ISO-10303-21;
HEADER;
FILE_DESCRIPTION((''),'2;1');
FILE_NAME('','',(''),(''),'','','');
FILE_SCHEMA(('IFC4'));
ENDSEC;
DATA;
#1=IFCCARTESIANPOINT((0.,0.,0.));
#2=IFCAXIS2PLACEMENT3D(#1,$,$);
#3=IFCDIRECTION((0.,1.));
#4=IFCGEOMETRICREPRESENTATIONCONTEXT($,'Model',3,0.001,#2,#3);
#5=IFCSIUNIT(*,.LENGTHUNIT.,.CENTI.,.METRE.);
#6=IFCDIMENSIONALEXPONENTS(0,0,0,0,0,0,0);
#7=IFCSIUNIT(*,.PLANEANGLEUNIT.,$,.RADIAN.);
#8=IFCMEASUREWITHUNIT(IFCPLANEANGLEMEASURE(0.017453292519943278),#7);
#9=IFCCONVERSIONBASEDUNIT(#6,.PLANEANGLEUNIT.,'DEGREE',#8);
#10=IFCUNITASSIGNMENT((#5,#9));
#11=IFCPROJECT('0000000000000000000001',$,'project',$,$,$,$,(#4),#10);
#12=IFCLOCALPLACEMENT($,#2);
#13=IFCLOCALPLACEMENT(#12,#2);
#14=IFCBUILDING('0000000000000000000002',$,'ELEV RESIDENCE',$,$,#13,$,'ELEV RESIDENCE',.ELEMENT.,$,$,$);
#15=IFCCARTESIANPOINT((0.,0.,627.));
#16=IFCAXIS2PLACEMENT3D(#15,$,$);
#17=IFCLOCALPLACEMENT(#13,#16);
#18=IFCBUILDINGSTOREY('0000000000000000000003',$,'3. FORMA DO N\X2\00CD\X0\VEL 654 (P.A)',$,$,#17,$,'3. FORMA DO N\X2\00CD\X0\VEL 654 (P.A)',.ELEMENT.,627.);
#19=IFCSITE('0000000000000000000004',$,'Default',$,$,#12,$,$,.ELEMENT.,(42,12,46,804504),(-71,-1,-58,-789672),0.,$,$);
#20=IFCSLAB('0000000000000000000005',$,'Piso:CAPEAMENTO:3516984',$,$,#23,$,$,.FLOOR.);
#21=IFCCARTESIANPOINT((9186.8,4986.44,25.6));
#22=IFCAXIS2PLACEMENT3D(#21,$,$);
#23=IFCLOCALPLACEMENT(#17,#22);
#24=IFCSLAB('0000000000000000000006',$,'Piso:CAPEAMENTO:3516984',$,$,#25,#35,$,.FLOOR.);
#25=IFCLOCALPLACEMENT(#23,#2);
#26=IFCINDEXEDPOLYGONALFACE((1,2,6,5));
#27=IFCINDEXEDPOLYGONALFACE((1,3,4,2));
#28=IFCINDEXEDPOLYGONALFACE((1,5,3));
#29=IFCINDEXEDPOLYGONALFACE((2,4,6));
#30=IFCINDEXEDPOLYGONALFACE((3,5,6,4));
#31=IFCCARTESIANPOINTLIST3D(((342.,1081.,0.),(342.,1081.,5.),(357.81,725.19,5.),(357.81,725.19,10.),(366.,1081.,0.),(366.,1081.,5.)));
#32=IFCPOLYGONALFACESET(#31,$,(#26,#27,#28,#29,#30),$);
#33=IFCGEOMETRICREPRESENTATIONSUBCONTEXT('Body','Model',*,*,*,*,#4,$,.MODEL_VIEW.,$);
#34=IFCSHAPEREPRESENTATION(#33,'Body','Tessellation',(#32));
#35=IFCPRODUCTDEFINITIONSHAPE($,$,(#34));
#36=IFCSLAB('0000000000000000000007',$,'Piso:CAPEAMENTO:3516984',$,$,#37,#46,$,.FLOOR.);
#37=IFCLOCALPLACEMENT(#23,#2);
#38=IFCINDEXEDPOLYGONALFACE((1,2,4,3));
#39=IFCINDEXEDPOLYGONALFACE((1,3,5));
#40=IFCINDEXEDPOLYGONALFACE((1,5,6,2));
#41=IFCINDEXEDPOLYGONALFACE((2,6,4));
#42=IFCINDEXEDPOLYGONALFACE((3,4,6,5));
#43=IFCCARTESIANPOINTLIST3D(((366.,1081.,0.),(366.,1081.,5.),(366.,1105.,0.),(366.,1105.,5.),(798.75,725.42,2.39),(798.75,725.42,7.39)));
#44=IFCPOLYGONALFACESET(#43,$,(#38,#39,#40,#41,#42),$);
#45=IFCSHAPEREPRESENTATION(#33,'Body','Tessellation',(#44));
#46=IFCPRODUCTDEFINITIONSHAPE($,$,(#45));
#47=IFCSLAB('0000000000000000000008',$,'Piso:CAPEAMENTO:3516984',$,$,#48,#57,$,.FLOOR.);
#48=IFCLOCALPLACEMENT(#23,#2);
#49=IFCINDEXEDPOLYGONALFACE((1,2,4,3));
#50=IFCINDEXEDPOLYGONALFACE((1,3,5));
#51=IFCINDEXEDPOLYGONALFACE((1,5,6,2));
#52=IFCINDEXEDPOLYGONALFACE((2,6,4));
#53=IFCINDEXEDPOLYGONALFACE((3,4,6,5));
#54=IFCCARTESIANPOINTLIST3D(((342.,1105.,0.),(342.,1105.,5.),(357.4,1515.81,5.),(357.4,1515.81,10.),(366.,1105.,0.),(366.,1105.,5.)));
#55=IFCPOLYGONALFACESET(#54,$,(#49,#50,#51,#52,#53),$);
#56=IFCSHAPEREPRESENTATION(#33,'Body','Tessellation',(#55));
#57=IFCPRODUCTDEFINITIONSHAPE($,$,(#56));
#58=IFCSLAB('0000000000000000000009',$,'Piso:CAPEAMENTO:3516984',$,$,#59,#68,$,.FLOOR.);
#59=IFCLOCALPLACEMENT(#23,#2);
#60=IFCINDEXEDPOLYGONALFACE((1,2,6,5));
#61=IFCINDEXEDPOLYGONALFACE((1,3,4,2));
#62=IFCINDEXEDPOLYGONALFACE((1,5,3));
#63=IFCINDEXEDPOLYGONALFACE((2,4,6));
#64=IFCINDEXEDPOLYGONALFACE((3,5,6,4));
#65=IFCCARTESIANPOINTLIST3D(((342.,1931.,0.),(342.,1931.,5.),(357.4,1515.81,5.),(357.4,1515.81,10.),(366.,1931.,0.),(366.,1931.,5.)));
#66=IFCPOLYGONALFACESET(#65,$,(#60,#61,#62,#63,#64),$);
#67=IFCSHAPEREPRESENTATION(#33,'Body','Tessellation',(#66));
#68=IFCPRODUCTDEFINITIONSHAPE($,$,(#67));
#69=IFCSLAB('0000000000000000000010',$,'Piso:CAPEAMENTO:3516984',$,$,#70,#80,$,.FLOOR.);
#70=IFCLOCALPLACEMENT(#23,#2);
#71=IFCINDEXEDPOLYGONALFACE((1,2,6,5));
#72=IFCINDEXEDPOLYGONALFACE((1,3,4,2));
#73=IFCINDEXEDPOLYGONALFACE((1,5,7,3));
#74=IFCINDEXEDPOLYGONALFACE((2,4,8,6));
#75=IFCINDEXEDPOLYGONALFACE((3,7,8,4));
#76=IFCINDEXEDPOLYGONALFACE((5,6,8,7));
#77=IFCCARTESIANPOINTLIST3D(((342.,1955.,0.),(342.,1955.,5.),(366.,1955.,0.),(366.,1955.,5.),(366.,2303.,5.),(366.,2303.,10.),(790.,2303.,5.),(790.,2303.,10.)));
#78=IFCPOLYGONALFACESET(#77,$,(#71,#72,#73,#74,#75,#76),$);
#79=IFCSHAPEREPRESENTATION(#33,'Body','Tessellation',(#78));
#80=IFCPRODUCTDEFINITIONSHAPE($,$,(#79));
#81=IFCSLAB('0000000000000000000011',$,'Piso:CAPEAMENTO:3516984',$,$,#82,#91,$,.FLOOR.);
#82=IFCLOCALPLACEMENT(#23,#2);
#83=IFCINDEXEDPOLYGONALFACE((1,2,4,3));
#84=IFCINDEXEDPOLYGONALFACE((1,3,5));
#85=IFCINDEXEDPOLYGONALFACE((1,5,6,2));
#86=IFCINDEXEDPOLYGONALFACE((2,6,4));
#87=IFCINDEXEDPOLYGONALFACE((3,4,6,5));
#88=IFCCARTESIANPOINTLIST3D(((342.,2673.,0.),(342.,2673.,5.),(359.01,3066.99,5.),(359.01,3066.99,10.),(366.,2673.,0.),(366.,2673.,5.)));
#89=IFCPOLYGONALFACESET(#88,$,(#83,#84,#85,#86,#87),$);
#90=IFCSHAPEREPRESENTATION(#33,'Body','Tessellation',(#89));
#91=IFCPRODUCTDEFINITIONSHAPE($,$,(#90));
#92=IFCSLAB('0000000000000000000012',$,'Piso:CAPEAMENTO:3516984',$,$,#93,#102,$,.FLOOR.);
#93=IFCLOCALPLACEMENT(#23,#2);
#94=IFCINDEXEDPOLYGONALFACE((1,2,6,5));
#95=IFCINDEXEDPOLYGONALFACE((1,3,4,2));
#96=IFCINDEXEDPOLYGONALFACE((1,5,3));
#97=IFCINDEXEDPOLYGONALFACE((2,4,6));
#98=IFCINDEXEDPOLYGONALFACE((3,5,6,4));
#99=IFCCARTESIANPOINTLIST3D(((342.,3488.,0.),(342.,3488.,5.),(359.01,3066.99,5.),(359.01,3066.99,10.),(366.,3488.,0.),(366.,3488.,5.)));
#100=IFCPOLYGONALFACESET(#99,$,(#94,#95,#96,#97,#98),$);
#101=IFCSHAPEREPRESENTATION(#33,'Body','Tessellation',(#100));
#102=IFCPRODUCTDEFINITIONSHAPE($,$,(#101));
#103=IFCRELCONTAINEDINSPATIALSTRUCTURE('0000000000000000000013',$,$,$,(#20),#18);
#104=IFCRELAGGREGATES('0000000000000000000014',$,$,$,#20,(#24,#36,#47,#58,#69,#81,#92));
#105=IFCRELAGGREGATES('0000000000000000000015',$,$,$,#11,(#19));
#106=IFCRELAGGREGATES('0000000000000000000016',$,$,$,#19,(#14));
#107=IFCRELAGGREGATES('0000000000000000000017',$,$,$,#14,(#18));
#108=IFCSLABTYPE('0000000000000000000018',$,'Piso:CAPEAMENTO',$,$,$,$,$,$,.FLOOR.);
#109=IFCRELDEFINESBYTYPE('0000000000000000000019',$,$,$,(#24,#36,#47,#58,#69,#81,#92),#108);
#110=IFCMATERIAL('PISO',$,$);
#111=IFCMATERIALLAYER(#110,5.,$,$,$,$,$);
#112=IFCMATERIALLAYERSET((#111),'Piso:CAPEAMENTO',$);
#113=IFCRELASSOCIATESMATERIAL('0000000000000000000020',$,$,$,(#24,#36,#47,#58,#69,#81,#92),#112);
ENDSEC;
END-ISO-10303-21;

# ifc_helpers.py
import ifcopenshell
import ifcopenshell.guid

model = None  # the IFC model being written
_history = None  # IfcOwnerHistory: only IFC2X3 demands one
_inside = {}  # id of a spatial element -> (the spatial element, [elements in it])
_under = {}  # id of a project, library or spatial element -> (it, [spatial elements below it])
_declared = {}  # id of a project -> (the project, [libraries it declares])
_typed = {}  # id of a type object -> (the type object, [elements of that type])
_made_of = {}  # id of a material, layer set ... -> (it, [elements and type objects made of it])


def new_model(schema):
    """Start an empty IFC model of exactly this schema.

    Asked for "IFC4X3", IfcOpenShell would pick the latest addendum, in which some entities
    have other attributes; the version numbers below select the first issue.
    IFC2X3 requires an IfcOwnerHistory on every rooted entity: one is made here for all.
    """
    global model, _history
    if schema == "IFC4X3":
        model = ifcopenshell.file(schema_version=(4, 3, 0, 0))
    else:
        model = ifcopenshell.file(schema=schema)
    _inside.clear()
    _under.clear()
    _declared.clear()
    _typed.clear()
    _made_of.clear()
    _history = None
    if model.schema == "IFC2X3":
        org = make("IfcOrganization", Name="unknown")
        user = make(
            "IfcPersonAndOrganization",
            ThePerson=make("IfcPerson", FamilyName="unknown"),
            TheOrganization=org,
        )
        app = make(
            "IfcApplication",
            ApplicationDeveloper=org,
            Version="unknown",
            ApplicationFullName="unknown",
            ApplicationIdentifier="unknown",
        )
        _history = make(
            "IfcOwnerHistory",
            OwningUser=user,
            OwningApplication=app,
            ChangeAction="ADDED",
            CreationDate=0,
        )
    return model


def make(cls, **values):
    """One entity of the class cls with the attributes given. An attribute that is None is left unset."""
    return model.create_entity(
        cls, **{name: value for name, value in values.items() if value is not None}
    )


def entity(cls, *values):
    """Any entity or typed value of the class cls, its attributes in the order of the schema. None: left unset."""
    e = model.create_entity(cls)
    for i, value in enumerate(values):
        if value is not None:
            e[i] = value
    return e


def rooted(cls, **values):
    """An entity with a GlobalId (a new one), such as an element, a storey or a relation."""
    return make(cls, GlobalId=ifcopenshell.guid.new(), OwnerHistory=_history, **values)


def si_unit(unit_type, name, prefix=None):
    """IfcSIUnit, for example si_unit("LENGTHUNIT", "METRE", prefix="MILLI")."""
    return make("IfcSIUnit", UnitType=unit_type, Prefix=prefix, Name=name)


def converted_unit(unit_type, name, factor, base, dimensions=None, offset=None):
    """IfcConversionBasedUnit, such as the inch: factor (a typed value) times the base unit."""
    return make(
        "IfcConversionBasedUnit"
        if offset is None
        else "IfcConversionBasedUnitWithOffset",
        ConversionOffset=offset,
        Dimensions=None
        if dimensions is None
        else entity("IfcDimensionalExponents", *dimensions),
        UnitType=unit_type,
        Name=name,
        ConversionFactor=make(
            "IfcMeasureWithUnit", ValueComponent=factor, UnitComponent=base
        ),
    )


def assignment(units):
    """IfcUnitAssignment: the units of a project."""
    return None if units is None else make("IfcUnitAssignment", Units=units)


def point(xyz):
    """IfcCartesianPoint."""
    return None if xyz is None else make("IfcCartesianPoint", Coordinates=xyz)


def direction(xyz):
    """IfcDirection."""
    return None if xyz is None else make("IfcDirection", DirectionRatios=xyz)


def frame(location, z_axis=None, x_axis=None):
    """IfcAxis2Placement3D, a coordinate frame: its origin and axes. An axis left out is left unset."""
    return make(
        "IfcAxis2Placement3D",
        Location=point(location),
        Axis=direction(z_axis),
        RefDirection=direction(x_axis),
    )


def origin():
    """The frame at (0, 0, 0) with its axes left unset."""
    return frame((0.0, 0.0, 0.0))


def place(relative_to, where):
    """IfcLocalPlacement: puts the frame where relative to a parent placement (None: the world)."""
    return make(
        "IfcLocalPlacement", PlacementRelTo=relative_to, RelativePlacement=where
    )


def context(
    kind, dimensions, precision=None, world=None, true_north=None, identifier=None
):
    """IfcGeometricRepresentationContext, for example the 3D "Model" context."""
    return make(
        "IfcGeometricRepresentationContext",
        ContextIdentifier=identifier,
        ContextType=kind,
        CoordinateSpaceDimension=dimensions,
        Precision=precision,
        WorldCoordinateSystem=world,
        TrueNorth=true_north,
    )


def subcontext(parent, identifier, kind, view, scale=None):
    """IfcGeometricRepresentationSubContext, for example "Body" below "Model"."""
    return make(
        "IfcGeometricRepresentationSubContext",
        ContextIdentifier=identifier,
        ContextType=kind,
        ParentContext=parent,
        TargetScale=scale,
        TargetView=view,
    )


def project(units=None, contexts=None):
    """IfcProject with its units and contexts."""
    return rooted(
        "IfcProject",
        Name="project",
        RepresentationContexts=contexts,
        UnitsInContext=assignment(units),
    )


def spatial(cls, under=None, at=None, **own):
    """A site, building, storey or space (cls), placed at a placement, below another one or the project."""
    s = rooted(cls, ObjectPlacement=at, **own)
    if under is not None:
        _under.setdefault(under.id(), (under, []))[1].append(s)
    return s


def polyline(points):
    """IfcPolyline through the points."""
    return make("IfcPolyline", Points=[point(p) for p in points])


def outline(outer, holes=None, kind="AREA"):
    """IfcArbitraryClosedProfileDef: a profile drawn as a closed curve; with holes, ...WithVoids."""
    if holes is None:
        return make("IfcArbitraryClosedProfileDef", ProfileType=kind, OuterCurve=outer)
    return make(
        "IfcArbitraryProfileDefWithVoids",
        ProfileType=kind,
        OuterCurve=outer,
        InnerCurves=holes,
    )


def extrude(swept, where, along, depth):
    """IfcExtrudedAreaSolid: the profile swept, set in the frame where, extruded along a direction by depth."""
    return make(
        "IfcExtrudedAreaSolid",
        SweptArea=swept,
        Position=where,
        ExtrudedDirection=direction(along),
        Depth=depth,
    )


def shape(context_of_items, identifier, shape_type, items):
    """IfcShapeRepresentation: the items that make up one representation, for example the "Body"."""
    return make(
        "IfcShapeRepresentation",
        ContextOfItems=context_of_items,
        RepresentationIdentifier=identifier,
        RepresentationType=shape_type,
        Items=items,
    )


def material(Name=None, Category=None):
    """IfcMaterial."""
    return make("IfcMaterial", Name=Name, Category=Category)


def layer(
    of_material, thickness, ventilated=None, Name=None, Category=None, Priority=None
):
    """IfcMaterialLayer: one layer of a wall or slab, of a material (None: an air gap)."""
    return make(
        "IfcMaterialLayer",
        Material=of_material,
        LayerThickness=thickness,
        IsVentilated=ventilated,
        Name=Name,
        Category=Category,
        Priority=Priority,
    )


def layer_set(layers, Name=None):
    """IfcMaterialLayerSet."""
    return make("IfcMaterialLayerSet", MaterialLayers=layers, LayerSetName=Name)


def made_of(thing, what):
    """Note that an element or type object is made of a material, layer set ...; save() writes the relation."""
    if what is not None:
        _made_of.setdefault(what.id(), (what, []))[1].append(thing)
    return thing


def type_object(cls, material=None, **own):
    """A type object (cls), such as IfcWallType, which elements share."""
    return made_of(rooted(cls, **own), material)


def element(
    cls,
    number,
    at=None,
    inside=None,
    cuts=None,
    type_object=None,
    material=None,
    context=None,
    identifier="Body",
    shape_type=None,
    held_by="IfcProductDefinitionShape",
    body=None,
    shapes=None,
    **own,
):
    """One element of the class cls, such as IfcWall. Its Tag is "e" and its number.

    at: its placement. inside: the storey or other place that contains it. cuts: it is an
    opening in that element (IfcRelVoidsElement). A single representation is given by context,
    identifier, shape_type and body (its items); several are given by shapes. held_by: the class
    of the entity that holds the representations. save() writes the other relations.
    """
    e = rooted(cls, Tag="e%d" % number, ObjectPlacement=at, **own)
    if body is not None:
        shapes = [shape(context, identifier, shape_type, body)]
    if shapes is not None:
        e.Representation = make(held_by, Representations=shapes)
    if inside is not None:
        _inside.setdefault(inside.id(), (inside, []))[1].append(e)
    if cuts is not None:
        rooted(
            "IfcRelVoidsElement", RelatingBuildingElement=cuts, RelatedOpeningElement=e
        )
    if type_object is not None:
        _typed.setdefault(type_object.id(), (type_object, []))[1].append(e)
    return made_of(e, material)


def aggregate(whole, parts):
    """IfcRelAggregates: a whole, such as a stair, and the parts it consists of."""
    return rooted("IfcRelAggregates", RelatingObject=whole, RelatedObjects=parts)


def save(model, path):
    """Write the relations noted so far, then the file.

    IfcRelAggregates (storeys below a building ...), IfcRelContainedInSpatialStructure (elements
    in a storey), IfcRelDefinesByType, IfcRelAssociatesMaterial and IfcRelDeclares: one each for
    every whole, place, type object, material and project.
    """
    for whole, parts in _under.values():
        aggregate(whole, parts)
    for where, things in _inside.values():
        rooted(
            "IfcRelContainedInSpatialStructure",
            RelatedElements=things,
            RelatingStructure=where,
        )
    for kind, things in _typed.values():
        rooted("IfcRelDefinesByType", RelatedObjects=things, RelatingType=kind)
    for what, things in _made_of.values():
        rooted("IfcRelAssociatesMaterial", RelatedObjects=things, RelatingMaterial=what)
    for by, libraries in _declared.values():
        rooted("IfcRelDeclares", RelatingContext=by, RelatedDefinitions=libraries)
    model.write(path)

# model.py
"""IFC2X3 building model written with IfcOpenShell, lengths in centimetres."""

from ifc_helpers import new_model, entity, si_unit, converted_unit, direction, frame, origin, place, context, subcontext, project, spatial, polyline, outline, extrude, material, layer, layer_set, type_object, element, aggregate, save


model = new_model("IFC2X3")

# Units and contexts
model_context = context("Model", 3, precision=0.001, world=origin(), true_north=direction((0.0, 1.0)))
body_context = subcontext(model_context, "Body", "Model", "MODEL_VIEW")
ifc_project = project(units=[si_unit("LENGTHUNIT", "METRE", prefix="CENTI"), converted_unit("PLANEANGLEUNIT", "DEGREE", entity("IfcPlaneAngleMeasure", 0.017453292519943278), si_unit("PLANEANGLEUNIT", "RADIAN"), dimensions=[0, 0, 0, 0, 0, 0, 0])], contexts=[model_context])

# Site, building, storey
site_placement = place(None, origin())
site = spatial("IfcSite", under=ifc_project, at=site_placement, Name="Default", CompositionType="ELEMENT", RefLatitude=(42, 12, 46, 804504), RefLongitude=(-71, -1, -58, -789672), RefElevation=0.0)
building_placement = place(site_placement, origin())
building = spatial("IfcBuilding", under=site, at=building_placement, Name="ELEV RESIDENCE", LongName="ELEV RESIDENCE", CompositionType="ELEMENT")
storey_placement = place(building_placement, frame((0.0, 0.0, 627.0)))
storey = spatial("IfcBuildingStorey", under=building, at=storey_placement, Name="3. FORMA DO NÍVEL 654 (P.A)", LongName="3. FORMA DO NÍVEL 654 (P.A)", CompositionType="ELEMENT", Elevation=627.0)

# Slabs
slab_1_placement = place(storey_placement, frame((9186.8, 4986.44, 25.6)))
slab_1 = element("IfcSlab", 1, at=slab_1_placement, inside=storey, Name="Piso:CAPEAMENTO:3516984", PredefinedType="FLOOR")
ifc_material_1 = material(Name="PISO")
ifc_layer = layer(ifc_material_1, 5.0)
ifc_layer_set = layer_set([ifc_layer], Name="Piso:CAPEAMENTO")
slab_type = type_object("IfcSlabType", Name="Piso:CAPEAMENTO", PredefinedType="FLOOR")
slab_2_placement = place(slab_1_placement, origin())
slab_2 = element("IfcSlab", 2, at=slab_2_placement, type_object=slab_type, material=ifc_layer_set, Name="Piso:CAPEAMENTO:3516984", PredefinedType="FLOOR", context=body_context, shape_type="SweptSolid", body=[
    extrude(outline(polyline([(12.0, 177.92), (-12.0, 177.92), (3.81, -177.92), (12.0, 177.92)])), frame((354.0, 903.09, 7.5), z_axis=(0.0, 0.014051, 0.999901), x_axis=(1.0, 0.0, 0.0)), (0.0, 0.014051, -0.999901), 5.0),
])
slab_3_placement = place(slab_1_placement, origin())
slab_3 = element("IfcSlab", 3, at=slab_3_placement, type_object=slab_type, material=ifc_layer_set, Name="Piso:CAPEAMENTO:3516984", PredefinedType="FLOOR", context=body_context, shape_type="SweptSolid", body=[
    extrude(outline(polyline([(-216.38, 165.79), (216.38, -189.79), (-216.38, 189.79), (-216.38, 165.79)])), frame((582.37, 915.21, 6.2), z_axis=(-0.00553, 0.0, 0.999985), x_axis=(0.999985, 0.0, 0.00553)), (-0.00553, 0.0, -0.999985), 5.0),
])
slab_4_placement = place(slab_1_placement, origin())
slab_4 = element("IfcSlab", 4, at=slab_4_placement, type_object=slab_type, material=ifc_layer_set, Name="Piso:CAPEAMENTO:3516984", PredefinedType="FLOOR", context=body_context, shape_type="SweptSolid", body=[
    extrude(outline(polyline([(-12.0, -205.42), (12.0, -205.42), (3.4, 205.42), (-12.0, -205.42)])), frame((354.0, 1310.4, 7.5), z_axis=(0.0, -0.01217, 0.999926), x_axis=(1.0, 0.0, 0.0)), (0.0, -0.01217, -0.999926), 5.0),
])
slab_5_placement = place(slab_1_placement, origin())
slab_5 = element("IfcSlab", 5, at=slab_5_placement, type_object=slab_type, material=ifc_layer_set, Name="Piso:CAPEAMENTO:3516984", PredefinedType="FLOOR", context=body_context, shape_type="SweptSolid", body=[
    extrude(outline(polyline([(12.0, 207.61), (-12.0, 207.61), (3.4, -207.61), (12.0, 207.61)])), frame((354.0, 1723.4, 7.5), z_axis=(0.0, 0.012042, 0.999927), x_axis=(1.0, 0.0, 0.0)), (0.0, 0.012042, -0.999927), 5.0),
])
slab_6_placement = place(slab_1_placement, origin())
slab_6 = element("IfcSlab", 6, at=slab_6_placement, type_object=slab_type, material=ifc_layer_set, Name="Piso:CAPEAMENTO:3516984", PredefinedType="FLOOR", context=body_context, shape_type="SweptSolid", body=[
    extrude(outline(polyline([(-224.0, -174.02), (-200.0, -174.02), (224.0, 174.02), (-200.0, 174.02), (-224.0, -174.02)])), frame((566.0, 2129.0, 7.5), z_axis=(0.0, -0.014366, 0.999897), x_axis=(1.0, 0.0, 0.0)), (0.0, -0.014366, -0.999897), 5.0),
])
slab_7_placement = place(slab_1_placement, origin())
slab_7 = element("IfcSlab", 7, at=slab_7_placement, type_object=slab_type, material=ifc_layer_set, Name="Piso:CAPEAMENTO:3516984", PredefinedType="FLOOR", context=body_context, shape_type="SweptSolid", body=[
    extrude(outline(polyline([(-12.0, -197.01), (12.0, -197.01), (5.01, 197.01), (-12.0, -197.01)])), frame((354.0, 2870.0, 7.5), z_axis=(0.0, -0.012689, 0.999919), x_axis=(1.0, 0.0, 0.0)), (0.0, -0.012689, -0.999919), 5.0),
])
slab_8_placement = place(slab_1_placement, origin())
slab_8 = element("IfcSlab", 8, at=slab_8_placement, type_object=slab_type, material=ifc_layer_set, Name="Piso:CAPEAMENTO:3516984", PredefinedType="FLOOR", context=body_context, shape_type="SweptSolid", body=[
    extrude(outline(polyline([(12.0, 210.52), (-12.0, 210.52), (5.01, -210.52), (12.0, 210.52)])), frame((354.0, 3277.5, 7.5), z_axis=(0.0, 0.011875, 0.999929), x_axis=(1.0, 0.0, 0.0)), (0.0, 0.011875, -0.999929), 5.0),
])
aggregate(slab_1, [slab_2, slab_3, slab_4, slab_5, slab_6, slab_7, slab_8])

save(model, "model.ifc")
